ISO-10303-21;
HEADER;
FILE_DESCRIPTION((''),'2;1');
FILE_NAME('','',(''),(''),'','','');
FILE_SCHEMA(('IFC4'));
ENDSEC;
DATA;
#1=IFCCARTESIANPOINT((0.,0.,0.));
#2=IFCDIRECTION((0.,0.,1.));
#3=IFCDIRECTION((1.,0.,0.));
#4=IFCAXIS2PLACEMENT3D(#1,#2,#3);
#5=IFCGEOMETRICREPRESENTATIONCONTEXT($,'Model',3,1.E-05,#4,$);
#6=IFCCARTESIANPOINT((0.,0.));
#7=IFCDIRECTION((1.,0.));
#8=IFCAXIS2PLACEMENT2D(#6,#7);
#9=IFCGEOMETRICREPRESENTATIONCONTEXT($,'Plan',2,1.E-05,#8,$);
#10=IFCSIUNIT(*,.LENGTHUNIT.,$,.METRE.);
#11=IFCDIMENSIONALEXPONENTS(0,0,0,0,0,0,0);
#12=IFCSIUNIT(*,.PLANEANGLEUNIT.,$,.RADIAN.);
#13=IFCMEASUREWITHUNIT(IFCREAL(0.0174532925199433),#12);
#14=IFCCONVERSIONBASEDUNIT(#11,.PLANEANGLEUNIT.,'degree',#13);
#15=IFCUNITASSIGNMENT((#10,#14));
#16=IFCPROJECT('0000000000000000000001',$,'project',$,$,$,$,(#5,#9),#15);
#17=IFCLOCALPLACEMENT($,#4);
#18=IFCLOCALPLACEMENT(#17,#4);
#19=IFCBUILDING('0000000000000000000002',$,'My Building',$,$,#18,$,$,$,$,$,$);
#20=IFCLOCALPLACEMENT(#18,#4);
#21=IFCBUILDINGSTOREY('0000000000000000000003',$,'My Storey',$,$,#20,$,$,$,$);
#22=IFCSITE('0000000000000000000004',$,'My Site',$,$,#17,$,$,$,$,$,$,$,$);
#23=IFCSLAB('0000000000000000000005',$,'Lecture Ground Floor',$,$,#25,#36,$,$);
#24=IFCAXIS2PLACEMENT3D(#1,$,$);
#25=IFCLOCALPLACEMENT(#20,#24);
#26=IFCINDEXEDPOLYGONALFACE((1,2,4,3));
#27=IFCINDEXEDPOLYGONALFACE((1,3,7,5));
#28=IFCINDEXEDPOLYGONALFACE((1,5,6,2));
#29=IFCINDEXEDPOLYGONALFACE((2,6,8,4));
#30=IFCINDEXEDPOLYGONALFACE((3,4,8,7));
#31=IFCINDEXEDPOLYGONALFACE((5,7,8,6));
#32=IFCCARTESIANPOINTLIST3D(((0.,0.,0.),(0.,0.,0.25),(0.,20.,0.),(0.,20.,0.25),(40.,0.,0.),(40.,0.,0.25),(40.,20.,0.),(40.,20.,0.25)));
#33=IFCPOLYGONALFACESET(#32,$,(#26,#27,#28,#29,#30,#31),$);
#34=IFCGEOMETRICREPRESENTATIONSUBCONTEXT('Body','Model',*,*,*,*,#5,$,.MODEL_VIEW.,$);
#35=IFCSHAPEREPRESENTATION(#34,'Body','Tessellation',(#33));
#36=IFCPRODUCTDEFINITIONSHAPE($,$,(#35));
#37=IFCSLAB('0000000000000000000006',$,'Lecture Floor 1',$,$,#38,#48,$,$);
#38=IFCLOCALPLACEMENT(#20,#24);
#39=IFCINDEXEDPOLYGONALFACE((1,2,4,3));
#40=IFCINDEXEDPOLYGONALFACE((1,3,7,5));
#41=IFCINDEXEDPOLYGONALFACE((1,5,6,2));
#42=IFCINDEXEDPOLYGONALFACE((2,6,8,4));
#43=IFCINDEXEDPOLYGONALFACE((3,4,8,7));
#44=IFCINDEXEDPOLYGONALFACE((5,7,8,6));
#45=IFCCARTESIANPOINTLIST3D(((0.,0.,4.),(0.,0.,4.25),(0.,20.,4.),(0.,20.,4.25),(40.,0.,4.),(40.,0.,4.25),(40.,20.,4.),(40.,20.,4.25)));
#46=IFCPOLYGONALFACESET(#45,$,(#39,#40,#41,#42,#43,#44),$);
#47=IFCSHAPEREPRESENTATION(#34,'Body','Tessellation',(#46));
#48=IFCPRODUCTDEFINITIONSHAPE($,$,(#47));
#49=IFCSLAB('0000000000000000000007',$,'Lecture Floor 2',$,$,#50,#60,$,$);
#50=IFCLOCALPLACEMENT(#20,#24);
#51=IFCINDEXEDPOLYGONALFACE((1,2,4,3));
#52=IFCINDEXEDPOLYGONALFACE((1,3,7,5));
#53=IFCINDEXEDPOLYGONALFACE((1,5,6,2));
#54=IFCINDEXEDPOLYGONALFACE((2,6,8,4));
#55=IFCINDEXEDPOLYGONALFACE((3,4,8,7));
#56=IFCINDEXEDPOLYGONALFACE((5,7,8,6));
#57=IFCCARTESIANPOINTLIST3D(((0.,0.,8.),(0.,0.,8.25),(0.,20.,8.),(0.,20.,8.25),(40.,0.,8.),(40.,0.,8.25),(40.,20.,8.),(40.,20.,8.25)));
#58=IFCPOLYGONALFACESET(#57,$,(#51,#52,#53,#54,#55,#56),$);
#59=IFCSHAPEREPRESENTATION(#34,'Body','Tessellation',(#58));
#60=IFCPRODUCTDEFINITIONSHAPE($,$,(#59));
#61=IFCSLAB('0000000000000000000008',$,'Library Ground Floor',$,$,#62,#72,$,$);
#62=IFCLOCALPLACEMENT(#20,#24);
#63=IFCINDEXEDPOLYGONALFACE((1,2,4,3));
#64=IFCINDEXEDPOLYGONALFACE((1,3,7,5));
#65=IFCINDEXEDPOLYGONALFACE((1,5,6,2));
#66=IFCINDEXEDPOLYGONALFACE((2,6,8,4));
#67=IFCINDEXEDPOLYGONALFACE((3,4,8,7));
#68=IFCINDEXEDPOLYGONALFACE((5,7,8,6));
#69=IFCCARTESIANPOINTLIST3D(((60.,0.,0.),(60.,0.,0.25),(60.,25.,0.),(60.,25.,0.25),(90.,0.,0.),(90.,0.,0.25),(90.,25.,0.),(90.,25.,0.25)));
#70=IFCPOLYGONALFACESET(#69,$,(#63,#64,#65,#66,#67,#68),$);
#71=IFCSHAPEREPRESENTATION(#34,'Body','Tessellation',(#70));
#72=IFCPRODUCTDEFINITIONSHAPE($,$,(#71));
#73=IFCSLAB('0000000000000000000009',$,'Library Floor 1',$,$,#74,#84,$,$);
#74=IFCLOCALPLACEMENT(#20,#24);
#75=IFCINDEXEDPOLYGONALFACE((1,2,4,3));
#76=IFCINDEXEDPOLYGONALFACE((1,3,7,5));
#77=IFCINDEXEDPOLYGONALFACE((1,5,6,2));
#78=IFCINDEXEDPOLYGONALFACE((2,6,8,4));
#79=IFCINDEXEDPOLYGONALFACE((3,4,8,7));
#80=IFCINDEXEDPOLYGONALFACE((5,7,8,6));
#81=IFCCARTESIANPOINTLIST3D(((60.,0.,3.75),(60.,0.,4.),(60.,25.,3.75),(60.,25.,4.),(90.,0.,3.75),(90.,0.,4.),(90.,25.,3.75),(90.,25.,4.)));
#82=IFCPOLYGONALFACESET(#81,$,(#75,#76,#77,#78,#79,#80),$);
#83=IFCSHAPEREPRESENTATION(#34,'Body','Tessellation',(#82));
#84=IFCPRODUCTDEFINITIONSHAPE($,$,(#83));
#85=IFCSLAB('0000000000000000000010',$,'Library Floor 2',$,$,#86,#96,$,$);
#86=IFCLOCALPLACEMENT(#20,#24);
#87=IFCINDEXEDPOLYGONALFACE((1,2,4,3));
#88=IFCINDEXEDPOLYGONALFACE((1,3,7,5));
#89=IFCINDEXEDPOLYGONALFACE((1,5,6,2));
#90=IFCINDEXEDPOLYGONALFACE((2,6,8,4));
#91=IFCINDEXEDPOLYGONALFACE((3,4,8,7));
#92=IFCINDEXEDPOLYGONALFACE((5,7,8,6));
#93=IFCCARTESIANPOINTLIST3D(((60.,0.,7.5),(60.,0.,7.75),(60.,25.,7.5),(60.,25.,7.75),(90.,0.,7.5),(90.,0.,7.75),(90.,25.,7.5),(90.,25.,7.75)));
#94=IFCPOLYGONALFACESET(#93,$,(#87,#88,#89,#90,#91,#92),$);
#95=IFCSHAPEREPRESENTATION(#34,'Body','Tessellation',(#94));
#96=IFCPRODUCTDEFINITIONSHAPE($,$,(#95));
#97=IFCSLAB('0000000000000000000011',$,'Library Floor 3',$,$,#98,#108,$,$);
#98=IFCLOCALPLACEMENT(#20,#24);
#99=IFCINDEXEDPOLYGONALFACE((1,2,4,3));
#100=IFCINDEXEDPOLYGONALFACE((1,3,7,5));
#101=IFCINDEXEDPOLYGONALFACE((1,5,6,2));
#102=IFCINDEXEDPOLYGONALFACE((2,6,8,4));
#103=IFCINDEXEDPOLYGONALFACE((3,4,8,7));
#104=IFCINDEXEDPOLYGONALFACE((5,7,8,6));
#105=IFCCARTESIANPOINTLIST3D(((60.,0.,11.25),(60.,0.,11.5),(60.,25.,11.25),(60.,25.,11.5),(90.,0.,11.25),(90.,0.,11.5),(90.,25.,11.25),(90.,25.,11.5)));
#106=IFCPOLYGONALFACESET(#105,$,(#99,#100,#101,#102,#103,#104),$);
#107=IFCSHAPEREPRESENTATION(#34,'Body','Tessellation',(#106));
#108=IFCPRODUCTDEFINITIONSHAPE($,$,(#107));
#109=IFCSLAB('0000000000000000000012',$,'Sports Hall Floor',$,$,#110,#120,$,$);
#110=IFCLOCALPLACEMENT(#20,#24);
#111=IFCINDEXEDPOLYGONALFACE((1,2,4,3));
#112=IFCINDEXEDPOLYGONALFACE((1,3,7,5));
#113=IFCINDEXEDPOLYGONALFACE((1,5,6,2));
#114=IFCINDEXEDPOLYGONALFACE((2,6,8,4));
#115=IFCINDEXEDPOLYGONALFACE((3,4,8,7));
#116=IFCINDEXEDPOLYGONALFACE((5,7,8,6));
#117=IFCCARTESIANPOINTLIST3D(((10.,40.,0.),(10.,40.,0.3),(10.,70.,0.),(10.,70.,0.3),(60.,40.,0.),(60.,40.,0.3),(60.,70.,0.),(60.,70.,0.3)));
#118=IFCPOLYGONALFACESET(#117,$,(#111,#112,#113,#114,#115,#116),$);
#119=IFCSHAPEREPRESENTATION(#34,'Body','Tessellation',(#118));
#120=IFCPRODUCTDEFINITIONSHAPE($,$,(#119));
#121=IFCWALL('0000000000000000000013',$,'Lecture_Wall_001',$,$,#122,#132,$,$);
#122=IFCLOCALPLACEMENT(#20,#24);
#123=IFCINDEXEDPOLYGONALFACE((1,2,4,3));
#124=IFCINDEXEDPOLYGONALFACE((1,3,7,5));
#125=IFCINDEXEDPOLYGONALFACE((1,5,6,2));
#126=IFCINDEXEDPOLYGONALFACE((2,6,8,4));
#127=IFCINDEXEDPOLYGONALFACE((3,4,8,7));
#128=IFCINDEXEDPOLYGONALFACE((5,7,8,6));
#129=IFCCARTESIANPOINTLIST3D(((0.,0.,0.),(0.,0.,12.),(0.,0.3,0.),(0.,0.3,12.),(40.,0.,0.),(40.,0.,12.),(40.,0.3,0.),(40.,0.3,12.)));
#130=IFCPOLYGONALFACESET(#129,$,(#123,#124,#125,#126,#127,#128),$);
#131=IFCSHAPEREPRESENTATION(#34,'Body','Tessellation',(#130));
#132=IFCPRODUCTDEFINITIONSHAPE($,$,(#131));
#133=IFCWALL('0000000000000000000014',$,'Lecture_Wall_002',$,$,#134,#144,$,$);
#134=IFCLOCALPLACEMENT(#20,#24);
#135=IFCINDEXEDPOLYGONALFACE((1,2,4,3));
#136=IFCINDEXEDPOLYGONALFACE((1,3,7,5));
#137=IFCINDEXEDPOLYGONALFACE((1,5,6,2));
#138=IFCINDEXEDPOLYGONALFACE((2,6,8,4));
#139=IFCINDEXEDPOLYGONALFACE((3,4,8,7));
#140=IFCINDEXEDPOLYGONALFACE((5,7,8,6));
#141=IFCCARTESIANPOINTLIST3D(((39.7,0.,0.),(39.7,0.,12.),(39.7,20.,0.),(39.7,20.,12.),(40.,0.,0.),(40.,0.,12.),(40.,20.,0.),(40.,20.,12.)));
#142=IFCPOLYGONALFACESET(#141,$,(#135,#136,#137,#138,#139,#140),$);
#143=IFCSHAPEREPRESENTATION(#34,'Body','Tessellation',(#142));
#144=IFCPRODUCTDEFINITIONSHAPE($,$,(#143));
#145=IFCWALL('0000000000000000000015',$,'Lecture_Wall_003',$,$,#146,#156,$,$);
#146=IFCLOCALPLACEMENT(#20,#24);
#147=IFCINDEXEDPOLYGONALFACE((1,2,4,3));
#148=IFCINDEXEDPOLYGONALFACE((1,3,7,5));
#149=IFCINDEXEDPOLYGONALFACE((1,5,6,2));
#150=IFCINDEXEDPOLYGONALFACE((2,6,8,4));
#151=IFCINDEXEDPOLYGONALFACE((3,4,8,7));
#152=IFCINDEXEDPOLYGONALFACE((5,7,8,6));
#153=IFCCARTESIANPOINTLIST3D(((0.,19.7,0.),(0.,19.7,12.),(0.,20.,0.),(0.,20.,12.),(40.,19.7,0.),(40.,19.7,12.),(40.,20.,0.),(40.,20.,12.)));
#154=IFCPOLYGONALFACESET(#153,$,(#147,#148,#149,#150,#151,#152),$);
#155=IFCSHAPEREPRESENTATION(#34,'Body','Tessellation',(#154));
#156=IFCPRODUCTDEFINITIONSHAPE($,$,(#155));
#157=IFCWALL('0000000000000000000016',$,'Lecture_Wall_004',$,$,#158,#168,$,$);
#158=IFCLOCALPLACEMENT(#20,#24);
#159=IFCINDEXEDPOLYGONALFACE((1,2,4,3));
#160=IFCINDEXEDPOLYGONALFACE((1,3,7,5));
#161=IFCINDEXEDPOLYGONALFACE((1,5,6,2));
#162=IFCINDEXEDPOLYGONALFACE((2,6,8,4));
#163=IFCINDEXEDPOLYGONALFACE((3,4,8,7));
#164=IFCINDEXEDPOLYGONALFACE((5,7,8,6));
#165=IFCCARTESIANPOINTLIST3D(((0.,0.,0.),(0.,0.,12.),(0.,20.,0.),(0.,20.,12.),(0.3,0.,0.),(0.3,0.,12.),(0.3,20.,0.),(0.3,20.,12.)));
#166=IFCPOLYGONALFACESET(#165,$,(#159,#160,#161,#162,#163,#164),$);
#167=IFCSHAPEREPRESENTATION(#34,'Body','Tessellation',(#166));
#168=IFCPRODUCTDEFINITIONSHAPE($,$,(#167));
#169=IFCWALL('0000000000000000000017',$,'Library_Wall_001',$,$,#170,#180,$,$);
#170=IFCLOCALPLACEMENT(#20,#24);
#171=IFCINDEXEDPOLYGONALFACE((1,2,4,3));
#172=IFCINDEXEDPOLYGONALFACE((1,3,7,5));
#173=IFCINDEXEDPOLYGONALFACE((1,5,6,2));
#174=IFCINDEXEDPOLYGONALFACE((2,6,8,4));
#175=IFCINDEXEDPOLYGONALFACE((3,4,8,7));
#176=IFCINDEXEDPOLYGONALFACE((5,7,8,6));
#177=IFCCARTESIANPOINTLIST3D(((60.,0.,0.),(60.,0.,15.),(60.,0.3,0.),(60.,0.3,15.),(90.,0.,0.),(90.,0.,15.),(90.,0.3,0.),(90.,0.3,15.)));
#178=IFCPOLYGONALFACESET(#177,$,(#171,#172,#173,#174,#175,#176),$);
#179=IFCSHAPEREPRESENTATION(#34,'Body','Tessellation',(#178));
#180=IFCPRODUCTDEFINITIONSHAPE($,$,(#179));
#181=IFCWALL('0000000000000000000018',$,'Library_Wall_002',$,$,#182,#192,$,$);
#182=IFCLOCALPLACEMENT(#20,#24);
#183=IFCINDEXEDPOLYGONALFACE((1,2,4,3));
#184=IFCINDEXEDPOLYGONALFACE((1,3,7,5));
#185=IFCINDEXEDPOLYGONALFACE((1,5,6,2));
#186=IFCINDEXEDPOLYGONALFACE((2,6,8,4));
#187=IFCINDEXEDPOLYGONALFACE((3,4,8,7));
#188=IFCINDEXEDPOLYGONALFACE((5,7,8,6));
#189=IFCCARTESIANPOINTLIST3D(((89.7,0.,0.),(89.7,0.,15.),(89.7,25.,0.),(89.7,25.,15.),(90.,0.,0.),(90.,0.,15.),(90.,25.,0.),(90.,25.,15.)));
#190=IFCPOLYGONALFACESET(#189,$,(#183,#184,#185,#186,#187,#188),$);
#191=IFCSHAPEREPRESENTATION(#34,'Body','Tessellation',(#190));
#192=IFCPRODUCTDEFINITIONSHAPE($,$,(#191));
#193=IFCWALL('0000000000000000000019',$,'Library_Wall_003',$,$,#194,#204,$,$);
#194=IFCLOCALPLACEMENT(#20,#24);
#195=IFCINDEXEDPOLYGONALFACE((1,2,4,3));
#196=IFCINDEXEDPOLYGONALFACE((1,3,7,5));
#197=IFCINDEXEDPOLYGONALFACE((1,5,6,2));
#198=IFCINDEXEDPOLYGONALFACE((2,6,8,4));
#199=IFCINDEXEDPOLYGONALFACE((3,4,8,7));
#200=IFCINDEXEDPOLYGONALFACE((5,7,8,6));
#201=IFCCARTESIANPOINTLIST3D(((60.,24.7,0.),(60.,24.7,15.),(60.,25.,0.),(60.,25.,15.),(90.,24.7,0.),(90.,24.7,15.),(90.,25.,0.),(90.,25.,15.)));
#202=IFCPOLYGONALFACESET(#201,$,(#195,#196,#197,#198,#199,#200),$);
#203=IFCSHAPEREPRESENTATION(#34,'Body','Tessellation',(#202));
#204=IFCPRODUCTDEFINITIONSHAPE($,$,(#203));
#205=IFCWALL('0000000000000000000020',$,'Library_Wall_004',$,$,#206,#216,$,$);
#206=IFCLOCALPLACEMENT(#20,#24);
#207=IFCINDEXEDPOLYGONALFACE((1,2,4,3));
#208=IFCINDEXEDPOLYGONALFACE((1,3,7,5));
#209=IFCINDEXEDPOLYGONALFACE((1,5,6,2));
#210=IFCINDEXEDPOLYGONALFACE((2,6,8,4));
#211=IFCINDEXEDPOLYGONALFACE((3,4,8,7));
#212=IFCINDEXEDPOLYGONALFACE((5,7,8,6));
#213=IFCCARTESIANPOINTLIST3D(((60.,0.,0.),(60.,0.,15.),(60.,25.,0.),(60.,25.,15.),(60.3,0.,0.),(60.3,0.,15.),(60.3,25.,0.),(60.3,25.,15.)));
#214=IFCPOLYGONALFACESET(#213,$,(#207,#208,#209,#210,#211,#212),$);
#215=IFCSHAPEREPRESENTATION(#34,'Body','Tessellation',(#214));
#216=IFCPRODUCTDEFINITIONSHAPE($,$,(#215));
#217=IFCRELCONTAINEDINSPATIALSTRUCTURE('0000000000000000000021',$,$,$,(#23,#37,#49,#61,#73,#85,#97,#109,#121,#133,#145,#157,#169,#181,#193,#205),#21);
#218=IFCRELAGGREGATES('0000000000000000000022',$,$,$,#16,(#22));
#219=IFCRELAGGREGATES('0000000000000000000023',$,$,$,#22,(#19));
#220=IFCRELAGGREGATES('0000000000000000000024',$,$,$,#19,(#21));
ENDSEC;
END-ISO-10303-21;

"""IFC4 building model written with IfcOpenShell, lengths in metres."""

from ifc_helpers import new_model, entity, si_unit, converted_unit, frame, origin_with_axes, origin_2d_with_axis, place, context, subcontext, project, spatial, indexed_curve, outline, extrude, element, save


model = new_model("IFC4")

# Units and contexts
model_context = context("Model", 3, precision=1e-05, world=origin_with_axes())
plan_context = context("Plan", 2, precision=1e-05, world=origin_2d_with_axis())
body_context = subcontext(model_context, "Body", "Model", "MODEL_VIEW")
ifc_project = project(units=[si_unit("LENGTHUNIT", "METRE"), converted_unit("PLANEANGLEUNIT", "degree", entity("IfcReal", 0.0174532925199433), si_unit("PLANEANGLEUNIT", "RADIAN"), dimensions=[0, 0, 0, 0, 0, 0, 0])], contexts=[model_context, plan_context])

# Site, building, storey
site_placement = place(None, origin_with_axes())
site = spatial("IfcSite", under=ifc_project, at=site_placement, Name="My Site")
building_placement = place(site_placement, origin_with_axes())
building = spatial("IfcBuilding", under=site, at=building_placement, Name="My Building")
storey_placement = place(building_placement, origin_with_axes())
storey = spatial("IfcBuildingStorey", under=building, at=storey_placement, Name="My Storey")

# Slabs
for number, where, z_axis, x_axis, name in (
    (1, (0.0, 0.0, 0.0), (0.0, 0.0, 1.0), (1.0, 0.0, 0.0), "Lecture Ground Floor"),
    (2, (0.0, 0.0, 4.0), (0.0, 0.0, 1.0), (1.0, 0.0, 0.0), "Lecture Floor 1"),
    (3, (0.0, 0.0, 8.0), (0.0, 0.0, 1.0), (1.0, 0.0, 0.0), "Lecture Floor 2"),
):
    element("IfcSlab", number, at=place(storey_placement, frame(where, z_axis=z_axis, x_axis=x_axis)), inside=storey, Name=name, context=body_context, shape_type="SweptSolid", body=[
        extrude(outline(indexed_curve([(0.0, 0.0), (40.0, 0.0), (40.0, 20.0), (0.0, 20.0)])), None, (0.0, 0.0, 1.0), 0.25),
    ])
for number, where, z_axis, x_axis, name in (
    (4, (60.0, 0.0, 0.0), (0.0, 0.0, 1.0), (1.0, 0.0, 0.0), "Library Ground Floor"),
    (5, (60.0, 0.0, 3.75), (0.0, 0.0, 1.0), (1.0, 0.0, 0.0), "Library Floor 1"),
    (6, (60.0, 0.0, 7.5), (0.0, 0.0, 1.0), (1.0, 0.0, 0.0), "Library Floor 2"),
    (7, (60.0, 0.0, 11.25), (0.0, 0.0, 1.0), (1.0, 0.0, 0.0), "Library Floor 3"),
):
    element("IfcSlab", number, at=place(storey_placement, frame(where, z_axis=z_axis, x_axis=x_axis)), inside=storey, Name=name, context=body_context, shape_type="SweptSolid", body=[
        extrude(outline(indexed_curve([(0.0, 0.0), (30.0, 0.0), (30.0, 25.0), (0.0, 25.0)])), None, (0.0, 0.0, 1.0), 0.25),
    ])
slab_placement = place(storey_placement, frame((10.0, 40.0, 0.0), z_axis=(0.0, 0.0, 1.0), x_axis=(1.0, 0.0, 0.0)))
element("IfcSlab", 8, at=slab_placement, inside=storey, Name="Sports Hall Floor", context=body_context, shape_type="SweptSolid", body=[
    extrude(outline(indexed_curve([(0.0, 0.0), (50.0, 0.0), (50.0, 30.0), (0.0, 30.0)])), None, (0.0, 0.0, 1.0), 0.3),
])

# Walls
wall_1_placement = place(storey_placement, origin_with_axes())
element("IfcWall", 9, at=wall_1_placement, inside=storey, Name="Lecture_Wall_001", context=body_context, shape_type="SweptSolid", body=[
    extrude(outline(indexed_curve([(0.0, 0.0), (0.0, 0.3), (40.0, 0.3), (40.0, 0.0), (0.0, 0.0)], self_intersect=False)), origin_with_axes(), (0.0, 0.0, 1.0), 12.0),
])
wall_2_placement = place(storey_placement, frame((40.0, 0.0, 0.0), z_axis=(0.0, 0.0, 1.0), x_axis=(0.0, 1.0, 0.0)))
element("IfcWall", 10, at=wall_2_placement, inside=storey, Name="Lecture_Wall_002", context=body_context, shape_type="SweptSolid", body=[
    extrude(outline(indexed_curve([(0.0, 0.0), (0.0, 0.3), (20.0, 0.3), (20.0, 0.0), (0.0, 0.0)], self_intersect=False)), origin_with_axes(), (0.0, 0.0, 1.0), 12.0),
])
wall_3_placement = place(storey_placement, frame((40.0, 20.0, 0.0), z_axis=(0.0, 0.0, 1.0), x_axis=(-1.0, 0.0, 0.0)))
element("IfcWall", 11, at=wall_3_placement, inside=storey, Name="Lecture_Wall_003", context=body_context, shape_type="SweptSolid", body=[
    extrude(outline(indexed_curve([(0.0, 0.0), (0.0, 0.3), (40.0, 0.3), (40.0, 0.0), (0.0, 0.0)], self_intersect=False)), origin_with_axes(), (0.0, 0.0, 1.0), 12.0),
])
wall_4_placement = place(storey_placement, frame((0.0, 20.0, 0.0), z_axis=(0.0, 0.0, 1.0), x_axis=(0.0, -1.0, 0.0)))
element("IfcWall", 12, at=wall_4_placement, inside=storey, Name="Lecture_Wall_004", context=body_context, shape_type="SweptSolid", body=[
    extrude(outline(indexed_curve([(0.0, 0.0), (0.0, 0.3), (20.0, 0.3), (20.0, 0.0), (0.0, 0.0)], self_intersect=False)), origin_with_axes(), (0.0, 0.0, 1.0), 12.0),
])
wall_5_placement = place(storey_placement, frame((60.0, 0.0, 0.0), z_axis=(0.0, 0.0, 1.0), x_axis=(1.0, 0.0, 0.0)))
element("IfcWall", 13, at=wall_5_placement, inside=storey, Name="Library_Wall_001", context=body_context, shape_type="SweptSolid", body=[
    extrude(outline(indexed_curve([(0.0, 0.0), (0.0, 0.3), (30.0, 0.3), (30.0, 0.0), (0.0, 0.0)], self_intersect=False)), origin_with_axes(), (0.0, 0.0, 1.0), 15.0),
])
wall_6_placement = place(storey_placement, frame((90.0, 0.0, 0.0), z_axis=(0.0, 0.0, 1.0), x_axis=(0.0, 1.0, 0.0)))
element("IfcWall", 14, at=wall_6_placement, inside=storey, Name="Library_Wall_002", context=body_context, shape_type="SweptSolid", body=[
    extrude(outline(indexed_curve([(0.0, 0.0), (0.0, 0.3), (25.0, 0.3), (25.0, 0.0), (0.0, 0.0)], self_intersect=False)), origin_with_axes(), (0.0, 0.0, 1.0), 15.0),
])
wall_7_placement = place(storey_placement, frame((90.0, 25.0, 0.0), z_axis=(0.0, 0.0, 1.0), x_axis=(-1.0, 0.0, 0.0)))
element("IfcWall", 15, at=wall_7_placement, inside=storey, Name="Library_Wall_003", context=body_context, shape_type="SweptSolid", body=[
    extrude(outline(indexed_curve([(0.0, 0.0), (0.0, 0.3), (30.0, 0.3), (30.0, 0.0), (0.0, 0.0)], self_intersect=False)), origin_with_axes(), (0.0, 0.0, 1.0), 15.0),
])
wall_8_placement = place(storey_placement, frame((60.0, 25.0, 0.0), z_axis=(0.0, 0.0, 1.0), x_axis=(0.0, -1.0, 0.0)))
element("IfcWall", 16, at=wall_8_placement, inside=storey, Name="Library_Wall_004", context=body_context, shape_type="SweptSolid", body=[
    extrude(outline(indexed_curve([(0.0, 0.0), (0.0, 0.3), (25.0, 0.3), (25.0, 0.0), (0.0, 0.0)], self_intersect=False)), origin_with_axes(), (0.0, 0.0, 1.0), 15.0),
])

save(model, "model.ifc")
